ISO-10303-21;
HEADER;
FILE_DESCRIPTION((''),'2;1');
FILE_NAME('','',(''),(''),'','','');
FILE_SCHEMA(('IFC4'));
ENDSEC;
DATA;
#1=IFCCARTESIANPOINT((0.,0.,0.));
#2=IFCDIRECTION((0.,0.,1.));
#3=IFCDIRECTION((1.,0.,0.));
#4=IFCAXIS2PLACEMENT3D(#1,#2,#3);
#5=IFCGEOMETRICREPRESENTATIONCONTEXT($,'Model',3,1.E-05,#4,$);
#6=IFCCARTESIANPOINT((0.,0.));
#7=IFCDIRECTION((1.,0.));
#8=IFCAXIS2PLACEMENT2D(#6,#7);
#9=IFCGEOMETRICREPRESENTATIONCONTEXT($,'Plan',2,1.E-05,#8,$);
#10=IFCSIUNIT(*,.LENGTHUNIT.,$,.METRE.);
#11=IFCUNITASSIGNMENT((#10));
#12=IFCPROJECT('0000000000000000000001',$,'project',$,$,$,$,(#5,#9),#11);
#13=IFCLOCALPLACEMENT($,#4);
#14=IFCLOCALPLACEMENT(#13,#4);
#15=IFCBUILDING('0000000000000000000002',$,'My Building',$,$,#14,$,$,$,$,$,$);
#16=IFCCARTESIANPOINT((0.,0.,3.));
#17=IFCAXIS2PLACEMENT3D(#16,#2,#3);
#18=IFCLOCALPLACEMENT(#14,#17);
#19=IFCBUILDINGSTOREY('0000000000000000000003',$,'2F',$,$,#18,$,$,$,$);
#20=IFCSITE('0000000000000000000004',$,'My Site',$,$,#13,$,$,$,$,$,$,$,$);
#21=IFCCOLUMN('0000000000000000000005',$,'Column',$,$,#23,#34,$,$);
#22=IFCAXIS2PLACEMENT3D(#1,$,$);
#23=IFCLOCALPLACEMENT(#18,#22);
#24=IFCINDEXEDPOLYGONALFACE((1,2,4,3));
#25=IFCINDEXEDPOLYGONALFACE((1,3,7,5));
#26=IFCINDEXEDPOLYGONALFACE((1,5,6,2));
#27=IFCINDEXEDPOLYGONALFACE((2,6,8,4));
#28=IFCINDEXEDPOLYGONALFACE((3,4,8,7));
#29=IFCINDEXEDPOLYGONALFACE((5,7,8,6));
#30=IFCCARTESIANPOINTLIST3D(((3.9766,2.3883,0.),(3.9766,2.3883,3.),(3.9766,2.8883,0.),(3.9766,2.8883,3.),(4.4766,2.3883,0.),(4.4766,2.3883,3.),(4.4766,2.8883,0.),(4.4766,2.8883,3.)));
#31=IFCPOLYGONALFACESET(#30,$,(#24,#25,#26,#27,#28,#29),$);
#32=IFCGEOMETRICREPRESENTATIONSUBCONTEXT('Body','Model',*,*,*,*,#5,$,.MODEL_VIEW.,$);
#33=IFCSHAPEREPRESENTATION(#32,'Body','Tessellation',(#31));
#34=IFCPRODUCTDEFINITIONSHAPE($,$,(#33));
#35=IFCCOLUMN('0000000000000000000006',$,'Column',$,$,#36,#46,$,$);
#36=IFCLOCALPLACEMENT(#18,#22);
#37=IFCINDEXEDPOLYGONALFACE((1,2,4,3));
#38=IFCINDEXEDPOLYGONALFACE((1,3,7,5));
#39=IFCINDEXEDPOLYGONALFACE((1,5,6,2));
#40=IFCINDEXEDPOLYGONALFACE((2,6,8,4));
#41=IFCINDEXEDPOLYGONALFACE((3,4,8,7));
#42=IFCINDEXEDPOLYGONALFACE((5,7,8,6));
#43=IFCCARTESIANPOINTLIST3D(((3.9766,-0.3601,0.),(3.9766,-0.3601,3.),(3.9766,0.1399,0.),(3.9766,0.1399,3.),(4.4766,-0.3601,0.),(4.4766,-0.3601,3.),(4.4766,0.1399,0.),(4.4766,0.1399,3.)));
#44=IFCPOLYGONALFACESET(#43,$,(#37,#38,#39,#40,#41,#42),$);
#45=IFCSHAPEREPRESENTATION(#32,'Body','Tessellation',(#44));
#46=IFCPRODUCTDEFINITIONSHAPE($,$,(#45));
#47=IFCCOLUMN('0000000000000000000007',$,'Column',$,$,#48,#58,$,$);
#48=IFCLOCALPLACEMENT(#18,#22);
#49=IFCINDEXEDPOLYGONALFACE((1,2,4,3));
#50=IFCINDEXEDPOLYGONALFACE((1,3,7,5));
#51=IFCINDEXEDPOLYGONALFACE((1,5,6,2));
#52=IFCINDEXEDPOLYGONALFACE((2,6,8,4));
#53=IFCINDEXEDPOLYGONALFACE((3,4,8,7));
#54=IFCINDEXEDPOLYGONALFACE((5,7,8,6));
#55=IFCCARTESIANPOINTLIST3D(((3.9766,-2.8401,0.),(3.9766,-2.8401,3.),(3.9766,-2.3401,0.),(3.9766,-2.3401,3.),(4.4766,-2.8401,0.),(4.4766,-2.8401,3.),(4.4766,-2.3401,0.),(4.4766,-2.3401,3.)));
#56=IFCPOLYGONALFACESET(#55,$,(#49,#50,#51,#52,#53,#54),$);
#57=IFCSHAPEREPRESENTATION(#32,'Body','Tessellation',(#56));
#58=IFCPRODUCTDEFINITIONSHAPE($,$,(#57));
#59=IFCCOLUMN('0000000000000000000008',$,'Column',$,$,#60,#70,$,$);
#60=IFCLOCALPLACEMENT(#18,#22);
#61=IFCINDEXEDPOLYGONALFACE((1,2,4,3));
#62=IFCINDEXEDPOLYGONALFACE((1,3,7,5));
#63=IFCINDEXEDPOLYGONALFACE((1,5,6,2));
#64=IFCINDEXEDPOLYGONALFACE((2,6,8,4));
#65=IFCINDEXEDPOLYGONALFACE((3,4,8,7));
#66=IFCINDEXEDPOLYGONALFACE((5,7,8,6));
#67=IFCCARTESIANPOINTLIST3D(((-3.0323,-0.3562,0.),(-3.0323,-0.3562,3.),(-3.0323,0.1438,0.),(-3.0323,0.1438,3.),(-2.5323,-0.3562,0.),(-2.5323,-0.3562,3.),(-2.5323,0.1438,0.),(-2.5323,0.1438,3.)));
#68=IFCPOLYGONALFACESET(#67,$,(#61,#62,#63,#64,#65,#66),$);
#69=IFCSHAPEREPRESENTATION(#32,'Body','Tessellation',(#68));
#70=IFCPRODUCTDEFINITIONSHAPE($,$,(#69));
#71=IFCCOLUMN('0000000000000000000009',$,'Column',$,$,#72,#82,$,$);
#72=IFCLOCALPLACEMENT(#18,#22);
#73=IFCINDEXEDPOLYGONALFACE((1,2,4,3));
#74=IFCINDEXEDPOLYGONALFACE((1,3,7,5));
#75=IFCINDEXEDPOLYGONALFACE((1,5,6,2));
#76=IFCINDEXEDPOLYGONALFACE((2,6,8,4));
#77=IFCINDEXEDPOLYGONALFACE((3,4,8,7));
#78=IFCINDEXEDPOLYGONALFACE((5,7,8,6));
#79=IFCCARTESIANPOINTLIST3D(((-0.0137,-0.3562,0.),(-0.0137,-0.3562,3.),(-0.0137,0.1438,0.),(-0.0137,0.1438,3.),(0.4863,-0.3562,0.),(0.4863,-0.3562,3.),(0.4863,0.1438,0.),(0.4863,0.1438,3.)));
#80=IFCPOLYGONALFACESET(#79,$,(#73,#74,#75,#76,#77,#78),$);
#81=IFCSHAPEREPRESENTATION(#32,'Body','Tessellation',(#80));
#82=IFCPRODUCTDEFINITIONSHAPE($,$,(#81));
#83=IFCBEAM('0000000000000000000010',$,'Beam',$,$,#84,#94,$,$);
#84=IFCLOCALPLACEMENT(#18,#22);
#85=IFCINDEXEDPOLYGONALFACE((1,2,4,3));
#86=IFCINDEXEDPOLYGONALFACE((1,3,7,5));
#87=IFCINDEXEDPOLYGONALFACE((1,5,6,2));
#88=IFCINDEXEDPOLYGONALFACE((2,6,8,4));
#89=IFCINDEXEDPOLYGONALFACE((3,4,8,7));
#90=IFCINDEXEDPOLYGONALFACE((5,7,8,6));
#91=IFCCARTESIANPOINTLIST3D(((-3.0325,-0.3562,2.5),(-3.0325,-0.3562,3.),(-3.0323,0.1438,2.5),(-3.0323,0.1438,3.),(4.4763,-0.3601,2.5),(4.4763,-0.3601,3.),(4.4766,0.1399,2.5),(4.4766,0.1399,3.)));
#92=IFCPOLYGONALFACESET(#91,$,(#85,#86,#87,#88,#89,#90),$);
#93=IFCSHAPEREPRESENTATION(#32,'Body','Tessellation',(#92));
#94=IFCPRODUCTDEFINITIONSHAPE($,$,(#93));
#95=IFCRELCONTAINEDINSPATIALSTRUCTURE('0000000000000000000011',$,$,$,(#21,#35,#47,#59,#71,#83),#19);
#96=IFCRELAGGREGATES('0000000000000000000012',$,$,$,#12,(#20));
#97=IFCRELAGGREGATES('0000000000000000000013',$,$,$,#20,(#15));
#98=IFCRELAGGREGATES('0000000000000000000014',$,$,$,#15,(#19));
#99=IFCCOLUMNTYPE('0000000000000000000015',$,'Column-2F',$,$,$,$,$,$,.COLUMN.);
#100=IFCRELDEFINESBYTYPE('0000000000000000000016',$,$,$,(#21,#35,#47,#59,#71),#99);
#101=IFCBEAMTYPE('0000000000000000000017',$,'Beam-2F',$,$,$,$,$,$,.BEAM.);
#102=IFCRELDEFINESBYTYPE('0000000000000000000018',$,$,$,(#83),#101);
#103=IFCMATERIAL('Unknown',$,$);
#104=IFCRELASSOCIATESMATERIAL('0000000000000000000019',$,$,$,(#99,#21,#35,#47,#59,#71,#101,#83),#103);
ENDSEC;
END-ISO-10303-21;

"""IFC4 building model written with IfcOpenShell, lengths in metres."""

from ifc_helpers import new_model, si_unit, frame, origin_with_axes, origin_2d_with_axis, place, context, subcontext, project, spatial, rectangle, extrude, material, material_profile, profile_set, profile_usage, type_object, element, save


model = new_model("IFC4")

# Units and contexts
model_context = context("Model", 3, precision=1e-05, world=origin_with_axes())
plan_context = context("Plan", 2, precision=1e-05, world=origin_2d_with_axis())
body_context_1 = subcontext(model_context, "Body", "Model", "MODEL_VIEW")
ifc_project = project(units=[si_unit("LENGTHUNIT", "METRE")], contexts=[model_context, plan_context])

# Site, building, storey
site_placement = place(None, origin_with_axes())
site = spatial("IfcSite", under=ifc_project, at=site_placement, Name="My Site")
building_placement = place(site_placement, origin_with_axes())
building = spatial("IfcBuilding", under=site, at=building_placement, Name="My Building")
storey_placement = place(building_placement, frame((0.0, 0.0, 3.0), z_axis=(0.0, 0.0, 1.0), x_axis=(1.0, 0.0, 0.0)))
storey = spatial("IfcBuildingStorey", under=building, at=storey_placement, Name="2F")

# Columns
ifc_material = material(Name="Unknown")
ifc_material_profile_1 = material_profile(ifc_material, rectangle(XDim=0.5, YDim=0.5))
ifc_profile_set_1 = profile_set([ifc_material_profile_1])
ifc_profile_usage_1 = profile_usage(ifc_profile_set_1, cardinal=7)
column_type = type_object("IfcColumnType", Name="Column-2F", PredefinedType="COLUMN", material=ifc_profile_set_1)
column_1_placement = place(storey_placement, frame((4.4766, 2.8883, 0.0), z_axis=(0.0, 0.0, 1.0), x_axis=(1.0, 0.0, 0.0)))
element("IfcColumn", 1, at=column_1_placement, inside=storey, type_object=column_type, material=ifc_profile_usage_1, Name="Column", context=body_context_1, shape_type="SweptSolid", body=[
    extrude(rectangle(XDim=0.5, YDim=0.5), frame((-0.25, -0.25, 0.0), z_axis=(0.0, 0.0, 1.0), x_axis=(1.0, 0.0, 0.0)), (0.0, 0.0, 1.0), 3.0),
])
ifc_profile_usage_2 = profile_usage(ifc_profile_set_1, cardinal=7)
column_2_placement = place(storey_placement, frame((4.4766, 0.1399, 0.0), z_axis=(0.0, 0.0, 1.0), x_axis=(1.0, 0.0, 0.0)))
element("IfcColumn", 2, at=column_2_placement, inside=storey, type_object=column_type, material=ifc_profile_usage_2, Name="Column", context=body_context_1, shape_type="SweptSolid", body=[
    extrude(rectangle(XDim=0.5, YDim=0.5), frame((-0.25, -0.25, 0.0), z_axis=(0.0, 0.0, 1.0), x_axis=(1.0, 0.0, 0.0)), (0.0, 0.0, 1.0), 3.0),
])
ifc_profile_usage_3 = profile_usage(ifc_profile_set_1, cardinal=7)
column_3_placement = place(storey_placement, frame((4.4766, -2.3401, 0.0), z_axis=(0.0, 0.0, 1.0), x_axis=(1.0, 0.0, 0.0)))
element("IfcColumn", 3, at=column_3_placement, inside=storey, type_object=column_type, material=ifc_profile_usage_3, Name="Column", context=body_context_1, shape_type="SweptSolid", body=[
    extrude(rectangle(XDim=0.5, YDim=0.5), frame((-0.25, -0.25, 0.0), z_axis=(0.0, 0.0, 1.0), x_axis=(1.0, 0.0, 0.0)), (0.0, 0.0, 1.0), 3.0),
])
ifc_profile_usage_4 = profile_usage(ifc_profile_set_1, cardinal=7)
column_4_placement = place(storey_placement, frame((-2.5323, 0.1438, 0.0), z_axis=(0.0, 0.0, 1.0), x_axis=(1.0, 0.0, 0.0)))
element("IfcColumn", 4, at=column_4_placement, inside=storey, type_object=column_type, material=ifc_profile_usage_4, Name="Column", context=body_context_1, shape_type="SweptSolid", body=[
    extrude(rectangle(XDim=0.5, YDim=0.5), frame((-0.25, -0.25, 0.0), z_axis=(0.0, 0.0, 1.0), x_axis=(1.0, 0.0, 0.0)), (0.0, 0.0, 1.0), 3.0),
])
ifc_profile_usage_5 = profile_usage(ifc_profile_set_1, cardinal=7)
column_5_placement = place(storey_placement, frame((0.4863, 0.1438, 0.0), z_axis=(0.0, 0.0, 1.0), x_axis=(1.0, 0.0, 0.0)))
element("IfcColumn", 5, at=column_5_placement, inside=storey, type_object=column_type, material=ifc_profile_usage_5, Name="Column", context=body_context_1, shape_type="SweptSolid", body=[
    extrude(rectangle(XDim=0.5, YDim=0.5), frame((-0.25, -0.25, 0.0), z_axis=(0.0, 0.0, 1.0), x_axis=(1.0, 0.0, 0.0)), (0.0, 0.0, 1.0), 3.0),
])

# Beam
ifc_material_profile_2 = material_profile(ifc_material, rectangle(XDim=0.5, YDim=0.5))
ifc_profile_set_2 = profile_set([ifc_material_profile_2])
ifc_profile_usage_6 = profile_usage(ifc_profile_set_2, cardinal=7)
beam_type = type_object("IfcBeamType", Name="Beam-2F", PredefinedType="BEAM", material=ifc_profile_set_2)
beam_placement = place(storey_placement, frame((-3.0323, 0.1438, 3.0), z_axis=(1.0, -0.000518, 0.0), x_axis=(0.000518, 1.0, 0.0)))
element("IfcBeam", 6, at=beam_placement, inside=storey, type_object=beam_type, material=ifc_profile_usage_6, Name="Beam", context=body_context_1, shape_type="SweptSolid", body=[
    extrude(rectangle(XDim=0.5, YDim=0.5), frame((-0.25, -0.25, 0.0), z_axis=(0.0, 0.0, 1.0), x_axis=(1.0, 0.0, 0.0)), (0.0, 0.0, 1.0), 7.5089),
])

save(model, "model.ifc")
